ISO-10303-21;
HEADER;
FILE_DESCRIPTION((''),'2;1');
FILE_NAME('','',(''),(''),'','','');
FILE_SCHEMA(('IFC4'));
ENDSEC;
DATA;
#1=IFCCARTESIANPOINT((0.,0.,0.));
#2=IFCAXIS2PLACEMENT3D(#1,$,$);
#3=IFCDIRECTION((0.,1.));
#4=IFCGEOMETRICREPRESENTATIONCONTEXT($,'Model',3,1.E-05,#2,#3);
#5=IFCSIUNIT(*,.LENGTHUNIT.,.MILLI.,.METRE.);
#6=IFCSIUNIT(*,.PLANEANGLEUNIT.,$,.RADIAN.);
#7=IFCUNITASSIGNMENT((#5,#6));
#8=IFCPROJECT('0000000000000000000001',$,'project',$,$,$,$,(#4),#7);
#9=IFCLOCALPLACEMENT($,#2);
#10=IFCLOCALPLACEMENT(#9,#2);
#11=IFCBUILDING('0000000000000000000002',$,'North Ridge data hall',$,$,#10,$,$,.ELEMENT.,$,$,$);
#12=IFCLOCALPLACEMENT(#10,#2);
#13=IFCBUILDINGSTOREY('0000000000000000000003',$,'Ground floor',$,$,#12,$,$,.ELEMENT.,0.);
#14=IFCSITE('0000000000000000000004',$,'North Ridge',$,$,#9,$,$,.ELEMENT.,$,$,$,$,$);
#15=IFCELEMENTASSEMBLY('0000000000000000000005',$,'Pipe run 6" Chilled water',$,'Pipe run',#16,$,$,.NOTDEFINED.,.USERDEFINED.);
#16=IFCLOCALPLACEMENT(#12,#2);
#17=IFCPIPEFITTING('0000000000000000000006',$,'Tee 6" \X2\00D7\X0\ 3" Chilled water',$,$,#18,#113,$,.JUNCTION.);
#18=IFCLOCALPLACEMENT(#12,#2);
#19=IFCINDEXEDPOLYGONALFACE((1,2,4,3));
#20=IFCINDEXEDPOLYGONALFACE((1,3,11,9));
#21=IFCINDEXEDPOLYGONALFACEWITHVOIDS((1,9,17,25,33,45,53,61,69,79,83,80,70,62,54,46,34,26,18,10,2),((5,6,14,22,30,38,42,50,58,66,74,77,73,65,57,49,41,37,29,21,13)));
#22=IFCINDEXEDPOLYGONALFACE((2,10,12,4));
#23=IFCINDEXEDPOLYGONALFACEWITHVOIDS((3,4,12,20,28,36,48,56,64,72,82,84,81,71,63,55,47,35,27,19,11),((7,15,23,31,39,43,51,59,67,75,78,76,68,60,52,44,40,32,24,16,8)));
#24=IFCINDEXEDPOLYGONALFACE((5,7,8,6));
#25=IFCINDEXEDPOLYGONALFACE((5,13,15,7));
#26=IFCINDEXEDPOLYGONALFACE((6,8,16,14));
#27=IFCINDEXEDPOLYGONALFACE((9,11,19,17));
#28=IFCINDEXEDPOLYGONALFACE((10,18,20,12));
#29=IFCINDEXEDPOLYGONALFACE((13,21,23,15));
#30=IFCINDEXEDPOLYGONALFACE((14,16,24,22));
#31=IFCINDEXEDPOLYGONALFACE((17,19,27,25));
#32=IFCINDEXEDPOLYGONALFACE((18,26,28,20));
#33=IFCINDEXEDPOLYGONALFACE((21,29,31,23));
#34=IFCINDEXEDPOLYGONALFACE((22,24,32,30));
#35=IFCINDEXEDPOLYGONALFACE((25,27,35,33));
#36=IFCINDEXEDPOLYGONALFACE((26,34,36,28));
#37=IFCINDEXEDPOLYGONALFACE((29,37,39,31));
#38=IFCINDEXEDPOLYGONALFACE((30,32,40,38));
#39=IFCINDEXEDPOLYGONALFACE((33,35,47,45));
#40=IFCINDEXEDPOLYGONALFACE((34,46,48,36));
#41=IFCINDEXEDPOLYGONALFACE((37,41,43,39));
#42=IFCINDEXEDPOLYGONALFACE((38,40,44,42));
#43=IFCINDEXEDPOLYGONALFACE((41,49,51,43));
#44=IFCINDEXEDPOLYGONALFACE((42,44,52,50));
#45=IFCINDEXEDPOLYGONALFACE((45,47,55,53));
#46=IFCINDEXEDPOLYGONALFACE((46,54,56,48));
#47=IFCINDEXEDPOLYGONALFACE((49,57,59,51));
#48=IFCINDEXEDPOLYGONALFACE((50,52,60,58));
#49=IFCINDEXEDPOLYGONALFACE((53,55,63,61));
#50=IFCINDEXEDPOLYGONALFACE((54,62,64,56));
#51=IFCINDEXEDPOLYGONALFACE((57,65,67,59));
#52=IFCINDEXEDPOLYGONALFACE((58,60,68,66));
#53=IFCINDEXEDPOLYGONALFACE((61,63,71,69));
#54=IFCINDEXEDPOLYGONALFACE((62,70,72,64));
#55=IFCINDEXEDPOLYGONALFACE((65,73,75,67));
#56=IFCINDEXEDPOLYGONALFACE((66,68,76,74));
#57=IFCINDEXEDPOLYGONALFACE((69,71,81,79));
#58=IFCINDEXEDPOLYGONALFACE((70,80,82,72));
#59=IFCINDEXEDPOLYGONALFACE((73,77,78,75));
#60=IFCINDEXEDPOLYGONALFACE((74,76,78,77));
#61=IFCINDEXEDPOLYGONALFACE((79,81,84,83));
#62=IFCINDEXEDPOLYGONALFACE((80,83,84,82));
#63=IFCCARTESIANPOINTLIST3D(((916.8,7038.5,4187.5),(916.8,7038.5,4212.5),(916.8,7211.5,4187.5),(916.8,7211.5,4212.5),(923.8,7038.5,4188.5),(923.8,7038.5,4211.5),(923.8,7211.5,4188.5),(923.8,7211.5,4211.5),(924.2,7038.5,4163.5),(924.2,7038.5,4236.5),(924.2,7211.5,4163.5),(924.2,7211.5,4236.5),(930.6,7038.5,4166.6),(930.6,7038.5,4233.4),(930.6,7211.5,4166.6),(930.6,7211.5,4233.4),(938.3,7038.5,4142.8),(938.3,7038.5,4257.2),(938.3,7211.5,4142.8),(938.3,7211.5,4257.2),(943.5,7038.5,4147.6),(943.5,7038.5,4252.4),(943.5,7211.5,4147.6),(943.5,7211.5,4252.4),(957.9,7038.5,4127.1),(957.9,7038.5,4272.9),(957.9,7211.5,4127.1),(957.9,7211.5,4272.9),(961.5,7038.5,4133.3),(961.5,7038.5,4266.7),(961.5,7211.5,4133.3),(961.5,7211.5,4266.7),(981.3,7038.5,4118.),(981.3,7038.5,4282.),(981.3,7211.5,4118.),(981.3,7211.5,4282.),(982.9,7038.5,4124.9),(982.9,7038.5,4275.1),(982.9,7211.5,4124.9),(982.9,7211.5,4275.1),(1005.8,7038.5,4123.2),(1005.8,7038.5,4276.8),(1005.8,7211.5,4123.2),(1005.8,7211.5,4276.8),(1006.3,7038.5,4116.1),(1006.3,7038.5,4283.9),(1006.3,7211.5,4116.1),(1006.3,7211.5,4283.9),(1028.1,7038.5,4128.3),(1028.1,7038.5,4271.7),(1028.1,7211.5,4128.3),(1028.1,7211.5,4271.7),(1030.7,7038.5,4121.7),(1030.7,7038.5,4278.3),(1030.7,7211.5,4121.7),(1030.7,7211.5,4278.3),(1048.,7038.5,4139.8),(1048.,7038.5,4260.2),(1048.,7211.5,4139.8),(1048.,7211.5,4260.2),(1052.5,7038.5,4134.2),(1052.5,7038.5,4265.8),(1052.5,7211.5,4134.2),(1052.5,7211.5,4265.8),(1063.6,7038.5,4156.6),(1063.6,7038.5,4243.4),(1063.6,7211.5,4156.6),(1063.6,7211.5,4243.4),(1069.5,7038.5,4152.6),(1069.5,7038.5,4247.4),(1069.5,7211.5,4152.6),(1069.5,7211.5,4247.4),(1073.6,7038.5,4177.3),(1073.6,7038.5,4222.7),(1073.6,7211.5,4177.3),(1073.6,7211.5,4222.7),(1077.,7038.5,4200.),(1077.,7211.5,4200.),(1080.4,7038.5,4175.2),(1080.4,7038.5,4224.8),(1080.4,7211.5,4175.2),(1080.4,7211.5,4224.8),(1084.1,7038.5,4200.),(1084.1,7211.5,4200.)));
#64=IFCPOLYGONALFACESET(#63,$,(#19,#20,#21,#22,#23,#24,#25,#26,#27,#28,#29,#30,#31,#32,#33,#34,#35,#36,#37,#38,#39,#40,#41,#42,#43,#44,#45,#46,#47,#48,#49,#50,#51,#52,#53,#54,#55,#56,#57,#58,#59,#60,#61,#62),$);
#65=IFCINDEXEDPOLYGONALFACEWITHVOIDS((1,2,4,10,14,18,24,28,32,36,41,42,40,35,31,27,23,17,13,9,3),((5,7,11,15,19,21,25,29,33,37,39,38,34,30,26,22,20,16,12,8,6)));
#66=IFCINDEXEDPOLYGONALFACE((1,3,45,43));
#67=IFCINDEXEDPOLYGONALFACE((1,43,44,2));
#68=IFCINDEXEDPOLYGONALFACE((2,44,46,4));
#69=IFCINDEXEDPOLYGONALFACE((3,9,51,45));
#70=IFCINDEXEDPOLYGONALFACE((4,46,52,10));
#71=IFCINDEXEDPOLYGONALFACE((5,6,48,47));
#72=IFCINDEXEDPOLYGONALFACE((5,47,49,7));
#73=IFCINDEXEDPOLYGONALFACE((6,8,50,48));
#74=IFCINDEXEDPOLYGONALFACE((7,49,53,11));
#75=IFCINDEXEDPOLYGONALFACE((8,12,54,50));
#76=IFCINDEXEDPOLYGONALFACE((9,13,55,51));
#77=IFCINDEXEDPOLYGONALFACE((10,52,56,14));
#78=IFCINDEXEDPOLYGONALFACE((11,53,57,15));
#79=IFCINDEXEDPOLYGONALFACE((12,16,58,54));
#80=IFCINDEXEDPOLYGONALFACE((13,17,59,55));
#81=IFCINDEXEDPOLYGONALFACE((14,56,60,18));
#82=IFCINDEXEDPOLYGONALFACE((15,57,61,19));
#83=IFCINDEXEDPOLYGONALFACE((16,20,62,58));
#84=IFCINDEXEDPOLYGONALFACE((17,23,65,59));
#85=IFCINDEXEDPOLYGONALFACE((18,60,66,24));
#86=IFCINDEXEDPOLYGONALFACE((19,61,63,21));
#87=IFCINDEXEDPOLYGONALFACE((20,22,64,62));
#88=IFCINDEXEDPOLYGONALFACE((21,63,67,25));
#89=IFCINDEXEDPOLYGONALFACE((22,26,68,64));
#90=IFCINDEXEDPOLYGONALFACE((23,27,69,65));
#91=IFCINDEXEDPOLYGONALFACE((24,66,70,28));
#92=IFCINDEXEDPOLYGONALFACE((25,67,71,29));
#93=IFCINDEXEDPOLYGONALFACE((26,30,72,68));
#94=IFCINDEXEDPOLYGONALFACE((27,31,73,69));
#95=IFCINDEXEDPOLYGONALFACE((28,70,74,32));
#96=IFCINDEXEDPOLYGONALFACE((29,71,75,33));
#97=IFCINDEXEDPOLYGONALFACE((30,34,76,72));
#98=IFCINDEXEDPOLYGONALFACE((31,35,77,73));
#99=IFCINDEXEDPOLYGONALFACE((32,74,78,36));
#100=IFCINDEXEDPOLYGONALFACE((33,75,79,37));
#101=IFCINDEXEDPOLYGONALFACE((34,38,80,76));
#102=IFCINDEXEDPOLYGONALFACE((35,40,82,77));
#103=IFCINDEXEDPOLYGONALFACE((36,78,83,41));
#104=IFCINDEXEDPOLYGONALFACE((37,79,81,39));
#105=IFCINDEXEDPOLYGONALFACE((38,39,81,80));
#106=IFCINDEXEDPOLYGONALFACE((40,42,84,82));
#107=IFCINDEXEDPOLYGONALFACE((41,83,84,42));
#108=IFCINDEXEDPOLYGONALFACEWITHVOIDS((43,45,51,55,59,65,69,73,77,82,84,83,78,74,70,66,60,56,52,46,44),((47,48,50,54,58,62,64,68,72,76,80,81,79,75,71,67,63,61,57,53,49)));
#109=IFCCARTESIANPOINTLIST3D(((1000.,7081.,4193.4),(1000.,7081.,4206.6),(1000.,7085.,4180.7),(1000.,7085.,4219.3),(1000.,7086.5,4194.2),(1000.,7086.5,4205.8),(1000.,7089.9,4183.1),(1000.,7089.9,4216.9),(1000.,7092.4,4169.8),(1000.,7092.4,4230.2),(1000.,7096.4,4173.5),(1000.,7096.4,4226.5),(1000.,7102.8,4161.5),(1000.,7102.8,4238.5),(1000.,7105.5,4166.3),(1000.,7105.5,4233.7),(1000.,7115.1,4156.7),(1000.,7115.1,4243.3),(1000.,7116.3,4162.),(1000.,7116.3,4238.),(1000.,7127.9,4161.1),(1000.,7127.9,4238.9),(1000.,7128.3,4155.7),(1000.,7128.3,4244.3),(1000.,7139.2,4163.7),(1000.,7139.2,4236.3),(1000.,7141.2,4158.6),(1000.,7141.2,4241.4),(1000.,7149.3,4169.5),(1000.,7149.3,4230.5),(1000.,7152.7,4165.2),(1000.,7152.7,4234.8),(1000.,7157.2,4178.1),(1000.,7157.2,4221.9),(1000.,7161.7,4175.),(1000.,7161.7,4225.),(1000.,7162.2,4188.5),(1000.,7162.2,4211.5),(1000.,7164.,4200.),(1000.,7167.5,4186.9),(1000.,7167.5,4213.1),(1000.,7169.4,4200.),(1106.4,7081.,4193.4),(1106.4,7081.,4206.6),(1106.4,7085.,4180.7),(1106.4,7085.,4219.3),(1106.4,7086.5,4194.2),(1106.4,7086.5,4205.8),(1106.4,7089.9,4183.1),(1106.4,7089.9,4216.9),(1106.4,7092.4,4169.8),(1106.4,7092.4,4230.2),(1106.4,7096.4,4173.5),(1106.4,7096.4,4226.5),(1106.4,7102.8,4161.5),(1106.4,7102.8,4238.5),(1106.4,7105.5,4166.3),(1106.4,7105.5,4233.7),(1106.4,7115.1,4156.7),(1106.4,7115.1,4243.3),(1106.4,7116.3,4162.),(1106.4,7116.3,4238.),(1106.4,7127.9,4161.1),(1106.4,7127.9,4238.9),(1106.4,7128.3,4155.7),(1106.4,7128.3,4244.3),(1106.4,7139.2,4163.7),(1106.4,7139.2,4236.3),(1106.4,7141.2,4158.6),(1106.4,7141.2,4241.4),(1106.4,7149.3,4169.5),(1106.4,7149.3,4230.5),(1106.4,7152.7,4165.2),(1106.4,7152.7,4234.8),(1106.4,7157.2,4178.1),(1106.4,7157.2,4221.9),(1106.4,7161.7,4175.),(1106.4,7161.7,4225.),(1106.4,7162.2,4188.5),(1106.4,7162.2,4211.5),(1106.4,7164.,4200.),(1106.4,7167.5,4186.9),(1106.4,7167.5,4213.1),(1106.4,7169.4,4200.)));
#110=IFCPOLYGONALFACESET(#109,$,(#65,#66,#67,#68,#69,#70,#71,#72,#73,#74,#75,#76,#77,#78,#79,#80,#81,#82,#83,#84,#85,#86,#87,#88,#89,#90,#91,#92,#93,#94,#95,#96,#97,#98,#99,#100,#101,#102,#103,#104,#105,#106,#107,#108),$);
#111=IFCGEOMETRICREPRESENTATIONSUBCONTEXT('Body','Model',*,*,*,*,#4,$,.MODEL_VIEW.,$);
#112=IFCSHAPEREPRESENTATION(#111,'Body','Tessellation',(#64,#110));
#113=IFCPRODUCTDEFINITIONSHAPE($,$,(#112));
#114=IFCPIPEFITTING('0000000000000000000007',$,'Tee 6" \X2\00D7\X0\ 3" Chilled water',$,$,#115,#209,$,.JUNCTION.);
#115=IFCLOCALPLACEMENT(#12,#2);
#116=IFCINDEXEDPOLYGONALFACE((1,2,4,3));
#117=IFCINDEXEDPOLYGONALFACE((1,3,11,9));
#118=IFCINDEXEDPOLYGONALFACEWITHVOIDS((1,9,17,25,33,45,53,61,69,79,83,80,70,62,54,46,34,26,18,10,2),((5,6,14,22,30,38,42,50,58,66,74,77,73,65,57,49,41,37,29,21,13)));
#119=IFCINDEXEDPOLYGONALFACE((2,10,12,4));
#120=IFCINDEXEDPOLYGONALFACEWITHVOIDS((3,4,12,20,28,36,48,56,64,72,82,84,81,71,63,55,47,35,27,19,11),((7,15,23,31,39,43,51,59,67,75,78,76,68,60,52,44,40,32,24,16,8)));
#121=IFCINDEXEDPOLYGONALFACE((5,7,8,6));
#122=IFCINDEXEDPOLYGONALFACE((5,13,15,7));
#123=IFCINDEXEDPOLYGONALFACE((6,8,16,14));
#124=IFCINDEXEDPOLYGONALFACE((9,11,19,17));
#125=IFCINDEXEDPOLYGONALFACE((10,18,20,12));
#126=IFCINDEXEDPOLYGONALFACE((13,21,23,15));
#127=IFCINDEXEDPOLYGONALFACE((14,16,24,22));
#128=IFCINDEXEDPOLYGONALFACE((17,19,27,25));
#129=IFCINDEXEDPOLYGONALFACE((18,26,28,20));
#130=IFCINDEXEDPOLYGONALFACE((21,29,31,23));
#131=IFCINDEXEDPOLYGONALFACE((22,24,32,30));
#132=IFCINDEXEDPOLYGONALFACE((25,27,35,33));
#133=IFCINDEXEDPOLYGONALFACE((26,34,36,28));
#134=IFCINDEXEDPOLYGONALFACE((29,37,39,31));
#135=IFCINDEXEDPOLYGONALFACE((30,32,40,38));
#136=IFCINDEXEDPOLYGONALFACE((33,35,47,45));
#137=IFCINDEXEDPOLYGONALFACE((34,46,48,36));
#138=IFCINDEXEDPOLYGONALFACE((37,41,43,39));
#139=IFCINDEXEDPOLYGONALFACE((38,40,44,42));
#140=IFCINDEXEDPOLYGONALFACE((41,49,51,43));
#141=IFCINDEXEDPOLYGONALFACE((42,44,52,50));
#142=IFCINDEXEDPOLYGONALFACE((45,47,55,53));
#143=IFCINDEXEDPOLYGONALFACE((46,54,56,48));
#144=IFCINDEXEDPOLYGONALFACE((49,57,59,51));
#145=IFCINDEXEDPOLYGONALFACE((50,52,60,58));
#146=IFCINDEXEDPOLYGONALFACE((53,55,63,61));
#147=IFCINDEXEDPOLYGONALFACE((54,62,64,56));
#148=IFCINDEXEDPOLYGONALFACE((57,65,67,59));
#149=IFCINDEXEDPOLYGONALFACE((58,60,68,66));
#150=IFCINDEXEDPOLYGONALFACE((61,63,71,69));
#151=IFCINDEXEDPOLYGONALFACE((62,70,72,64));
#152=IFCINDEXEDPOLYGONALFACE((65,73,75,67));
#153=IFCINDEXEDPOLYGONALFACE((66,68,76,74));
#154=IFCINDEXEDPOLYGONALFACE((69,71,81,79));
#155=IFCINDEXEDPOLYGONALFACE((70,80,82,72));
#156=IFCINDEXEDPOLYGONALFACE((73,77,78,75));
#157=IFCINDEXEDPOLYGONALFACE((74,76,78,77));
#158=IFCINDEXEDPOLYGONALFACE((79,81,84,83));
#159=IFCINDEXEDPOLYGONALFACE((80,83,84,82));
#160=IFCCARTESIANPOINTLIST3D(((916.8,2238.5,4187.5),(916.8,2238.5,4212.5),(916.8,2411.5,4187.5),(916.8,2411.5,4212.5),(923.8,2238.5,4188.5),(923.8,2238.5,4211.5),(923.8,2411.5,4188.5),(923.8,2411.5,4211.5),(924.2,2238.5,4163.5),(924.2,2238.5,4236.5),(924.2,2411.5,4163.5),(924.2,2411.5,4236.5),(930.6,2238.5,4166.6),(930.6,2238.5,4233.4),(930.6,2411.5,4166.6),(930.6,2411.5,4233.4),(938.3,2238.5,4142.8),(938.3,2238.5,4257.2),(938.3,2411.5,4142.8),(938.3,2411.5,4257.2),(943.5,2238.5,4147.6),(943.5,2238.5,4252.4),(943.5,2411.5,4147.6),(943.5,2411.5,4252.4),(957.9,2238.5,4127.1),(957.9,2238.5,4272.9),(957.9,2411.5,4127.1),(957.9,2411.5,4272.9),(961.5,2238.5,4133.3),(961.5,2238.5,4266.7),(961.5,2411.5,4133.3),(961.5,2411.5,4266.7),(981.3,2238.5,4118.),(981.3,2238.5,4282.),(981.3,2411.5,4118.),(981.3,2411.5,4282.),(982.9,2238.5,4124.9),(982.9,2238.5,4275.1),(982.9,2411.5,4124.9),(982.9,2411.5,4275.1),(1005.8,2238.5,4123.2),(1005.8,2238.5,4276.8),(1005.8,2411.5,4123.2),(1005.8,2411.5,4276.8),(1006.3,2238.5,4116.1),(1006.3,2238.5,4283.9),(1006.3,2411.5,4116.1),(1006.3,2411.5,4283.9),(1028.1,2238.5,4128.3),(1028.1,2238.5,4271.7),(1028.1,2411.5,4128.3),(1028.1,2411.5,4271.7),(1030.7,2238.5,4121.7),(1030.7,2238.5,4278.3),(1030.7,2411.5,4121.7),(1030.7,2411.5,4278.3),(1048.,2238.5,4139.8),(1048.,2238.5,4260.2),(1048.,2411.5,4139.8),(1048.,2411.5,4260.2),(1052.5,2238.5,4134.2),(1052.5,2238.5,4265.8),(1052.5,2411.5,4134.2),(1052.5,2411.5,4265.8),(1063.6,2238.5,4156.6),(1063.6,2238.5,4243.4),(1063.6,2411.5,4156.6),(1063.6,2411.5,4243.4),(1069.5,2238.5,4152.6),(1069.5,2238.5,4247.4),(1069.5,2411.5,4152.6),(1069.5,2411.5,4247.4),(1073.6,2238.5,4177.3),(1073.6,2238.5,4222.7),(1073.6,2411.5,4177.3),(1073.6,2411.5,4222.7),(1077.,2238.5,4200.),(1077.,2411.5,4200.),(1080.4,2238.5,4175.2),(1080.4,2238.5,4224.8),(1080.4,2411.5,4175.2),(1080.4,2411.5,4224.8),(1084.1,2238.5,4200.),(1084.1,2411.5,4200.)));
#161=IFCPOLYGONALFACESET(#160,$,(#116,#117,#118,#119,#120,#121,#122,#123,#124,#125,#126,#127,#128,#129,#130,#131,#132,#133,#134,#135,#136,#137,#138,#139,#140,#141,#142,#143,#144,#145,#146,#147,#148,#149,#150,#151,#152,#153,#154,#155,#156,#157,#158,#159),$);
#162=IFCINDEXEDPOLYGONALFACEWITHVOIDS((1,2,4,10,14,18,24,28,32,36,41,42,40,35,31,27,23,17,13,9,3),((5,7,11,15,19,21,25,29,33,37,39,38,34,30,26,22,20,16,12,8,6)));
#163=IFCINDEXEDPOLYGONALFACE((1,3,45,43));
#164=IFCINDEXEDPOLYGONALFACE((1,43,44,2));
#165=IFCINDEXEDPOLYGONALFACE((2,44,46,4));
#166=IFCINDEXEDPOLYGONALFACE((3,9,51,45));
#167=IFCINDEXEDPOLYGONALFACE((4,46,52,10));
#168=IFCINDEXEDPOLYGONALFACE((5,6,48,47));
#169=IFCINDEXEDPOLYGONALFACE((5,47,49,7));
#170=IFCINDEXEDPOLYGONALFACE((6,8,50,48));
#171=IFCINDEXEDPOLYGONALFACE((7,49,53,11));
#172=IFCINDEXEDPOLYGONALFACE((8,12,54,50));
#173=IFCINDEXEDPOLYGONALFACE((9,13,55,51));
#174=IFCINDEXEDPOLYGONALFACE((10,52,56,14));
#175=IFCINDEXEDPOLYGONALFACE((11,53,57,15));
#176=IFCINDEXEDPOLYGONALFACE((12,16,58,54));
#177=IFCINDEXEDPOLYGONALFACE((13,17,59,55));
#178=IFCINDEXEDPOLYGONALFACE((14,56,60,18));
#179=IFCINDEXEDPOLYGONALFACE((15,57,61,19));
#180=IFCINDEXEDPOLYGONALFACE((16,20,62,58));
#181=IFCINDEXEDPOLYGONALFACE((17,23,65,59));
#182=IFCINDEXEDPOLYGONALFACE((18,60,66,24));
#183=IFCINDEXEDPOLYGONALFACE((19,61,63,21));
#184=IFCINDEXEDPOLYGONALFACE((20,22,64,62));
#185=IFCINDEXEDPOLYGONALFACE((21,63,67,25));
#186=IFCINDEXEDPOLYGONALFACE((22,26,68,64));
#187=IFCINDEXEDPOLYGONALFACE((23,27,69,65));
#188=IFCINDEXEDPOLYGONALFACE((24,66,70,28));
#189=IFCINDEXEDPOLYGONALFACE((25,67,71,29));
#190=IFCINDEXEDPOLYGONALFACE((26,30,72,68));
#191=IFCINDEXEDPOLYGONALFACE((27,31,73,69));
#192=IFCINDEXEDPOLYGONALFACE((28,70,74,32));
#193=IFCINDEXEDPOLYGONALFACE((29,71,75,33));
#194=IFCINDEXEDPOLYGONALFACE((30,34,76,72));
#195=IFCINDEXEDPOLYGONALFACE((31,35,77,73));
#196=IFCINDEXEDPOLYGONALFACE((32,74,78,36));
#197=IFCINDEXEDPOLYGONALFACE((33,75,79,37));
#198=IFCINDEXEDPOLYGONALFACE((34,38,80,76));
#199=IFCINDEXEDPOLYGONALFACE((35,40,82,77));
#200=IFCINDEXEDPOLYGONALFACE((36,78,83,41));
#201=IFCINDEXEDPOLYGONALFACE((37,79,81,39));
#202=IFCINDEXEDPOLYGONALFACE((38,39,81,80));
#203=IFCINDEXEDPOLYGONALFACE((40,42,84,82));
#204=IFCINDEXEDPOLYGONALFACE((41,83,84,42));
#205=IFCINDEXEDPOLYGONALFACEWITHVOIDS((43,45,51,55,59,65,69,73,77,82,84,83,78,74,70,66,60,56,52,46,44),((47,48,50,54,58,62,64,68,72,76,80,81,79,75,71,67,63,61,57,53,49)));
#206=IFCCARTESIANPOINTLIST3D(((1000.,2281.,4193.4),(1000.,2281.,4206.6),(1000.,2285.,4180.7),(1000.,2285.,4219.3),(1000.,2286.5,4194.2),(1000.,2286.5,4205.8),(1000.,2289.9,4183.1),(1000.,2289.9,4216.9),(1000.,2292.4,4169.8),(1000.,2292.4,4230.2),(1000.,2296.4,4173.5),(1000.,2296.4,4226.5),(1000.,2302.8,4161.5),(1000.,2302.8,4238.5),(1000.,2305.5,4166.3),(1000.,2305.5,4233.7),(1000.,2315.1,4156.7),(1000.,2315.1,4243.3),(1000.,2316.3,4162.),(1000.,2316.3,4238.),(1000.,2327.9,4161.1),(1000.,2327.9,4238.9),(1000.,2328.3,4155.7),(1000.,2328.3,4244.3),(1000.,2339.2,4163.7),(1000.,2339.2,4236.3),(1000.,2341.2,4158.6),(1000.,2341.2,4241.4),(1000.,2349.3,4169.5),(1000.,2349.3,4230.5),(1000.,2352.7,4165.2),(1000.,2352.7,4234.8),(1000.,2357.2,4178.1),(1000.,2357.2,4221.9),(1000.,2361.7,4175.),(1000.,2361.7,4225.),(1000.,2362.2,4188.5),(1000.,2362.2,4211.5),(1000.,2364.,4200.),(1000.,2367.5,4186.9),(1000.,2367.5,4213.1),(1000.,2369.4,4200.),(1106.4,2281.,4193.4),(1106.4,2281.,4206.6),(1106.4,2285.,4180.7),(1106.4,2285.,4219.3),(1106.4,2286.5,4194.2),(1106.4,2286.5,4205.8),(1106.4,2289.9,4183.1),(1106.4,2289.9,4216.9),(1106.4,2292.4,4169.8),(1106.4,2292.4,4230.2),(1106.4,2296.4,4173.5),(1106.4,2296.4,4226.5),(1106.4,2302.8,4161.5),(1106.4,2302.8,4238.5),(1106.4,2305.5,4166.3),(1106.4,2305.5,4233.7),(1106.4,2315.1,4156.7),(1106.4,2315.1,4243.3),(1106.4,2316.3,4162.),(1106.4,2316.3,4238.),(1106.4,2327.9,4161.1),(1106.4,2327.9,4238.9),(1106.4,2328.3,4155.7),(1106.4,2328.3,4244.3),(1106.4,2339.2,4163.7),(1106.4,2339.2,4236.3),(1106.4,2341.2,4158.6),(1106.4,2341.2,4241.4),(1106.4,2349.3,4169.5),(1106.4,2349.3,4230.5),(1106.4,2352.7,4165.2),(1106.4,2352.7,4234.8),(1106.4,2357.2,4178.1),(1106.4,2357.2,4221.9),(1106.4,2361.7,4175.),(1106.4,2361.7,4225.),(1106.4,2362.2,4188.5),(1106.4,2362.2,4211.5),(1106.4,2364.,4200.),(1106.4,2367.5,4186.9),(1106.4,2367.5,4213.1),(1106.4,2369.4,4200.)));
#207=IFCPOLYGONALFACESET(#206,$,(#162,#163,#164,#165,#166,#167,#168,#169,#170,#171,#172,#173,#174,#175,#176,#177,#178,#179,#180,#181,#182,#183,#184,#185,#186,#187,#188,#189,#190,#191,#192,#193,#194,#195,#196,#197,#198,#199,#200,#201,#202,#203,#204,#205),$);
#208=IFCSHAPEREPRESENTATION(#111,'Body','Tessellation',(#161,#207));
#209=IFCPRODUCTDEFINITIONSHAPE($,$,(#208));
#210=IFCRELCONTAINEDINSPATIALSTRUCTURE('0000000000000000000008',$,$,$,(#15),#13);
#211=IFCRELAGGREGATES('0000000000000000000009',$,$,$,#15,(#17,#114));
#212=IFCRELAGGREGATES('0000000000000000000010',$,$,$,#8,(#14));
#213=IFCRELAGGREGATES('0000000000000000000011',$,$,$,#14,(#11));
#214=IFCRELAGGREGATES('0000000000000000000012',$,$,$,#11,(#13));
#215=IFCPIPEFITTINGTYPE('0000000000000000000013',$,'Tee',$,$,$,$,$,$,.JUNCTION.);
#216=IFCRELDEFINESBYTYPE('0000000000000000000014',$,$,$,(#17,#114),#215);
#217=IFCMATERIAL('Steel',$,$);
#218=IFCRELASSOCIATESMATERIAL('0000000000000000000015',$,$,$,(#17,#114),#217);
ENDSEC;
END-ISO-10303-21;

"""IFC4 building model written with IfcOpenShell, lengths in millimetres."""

from ifc_helpers import new_model, si_unit, direction, frame, origin, origin_with_axes, origin_2d, place, context, subcontext, project, spatial, hollow_circle, extrude, material, type_object, element, aggregate, save


model = new_model("IFC4")

# Units and contexts
model_context = context("Model", 3, precision=1e-05, world=origin(), true_north=direction((0.0, 1.0)))
body_context = subcontext(model_context, "Body", "Model", "MODEL_VIEW")
ifc_project = project(units=[si_unit("LENGTHUNIT", "METRE", prefix="MILLI"), si_unit("PLANEANGLEUNIT", "RADIAN")], contexts=[model_context])

# Site, building, storey
site_placement = place(None, origin())
site = spatial("IfcSite", under=ifc_project, at=site_placement, Name="North Ridge", CompositionType="ELEMENT")
building_placement = place(site_placement, origin())
building = spatial("IfcBuilding", under=site, at=building_placement, Name="North Ridge data hall", CompositionType="ELEMENT")
storey_placement = place(building_placement, origin())
storey = spatial("IfcBuildingStorey", under=building, at=storey_placement, Name="Ground floor", CompositionType="ELEMENT", Elevation=0.0)

# Element assembly
assembly_1_placement = place(storey_placement, origin_with_axes())
assembly_1 = element("IfcElementAssembly", 1, at=assembly_1_placement, inside=storey, Name="Pipe run 6\" Chilled water", ObjectType="Pipe run", AssemblyPlace="NOTDEFINED", PredefinedType="USERDEFINED")
ifc_material_1 = material(Name="Steel")

# Pipe fittings
pipe_fitting_type_1 = type_object("IfcPipeFittingType", Name="Tee", PredefinedType="JUNCTION")
pipe_fitting_1_placement = place(storey_placement, origin_with_axes())
pipe_fitting_1 = element("IfcPipeFitting", 2, at=pipe_fitting_1_placement, type_object=pipe_fitting_type_1, material=ifc_material_1, Name="Tee 6\" × 3\" Chilled water", PredefinedType="JUNCTION", context=body_context, shape_type="SweptSolid", body=[
    extrude(hollow_circle(Radius=84.1, WallThickness=7.1, at=origin_2d()), frame((1000.0, 7211.5, 4200.0), z_axis=(0.0, -1.0, 0.0), x_axis=(1.0, 0.0, 0.0)), (0.0, 0.0, 1.0), 173.0),
    extrude(hollow_circle(Radius=44.5, WallThickness=5.5, at=origin_2d()), frame((1000.0, 7125.0, 4200.0), z_axis=(1.0, 0.0, 0.0), x_axis=(0.0, 1.0, 0.0)), (0.0, 0.0, 1.0), 106.4),
])
pipe_fitting_2_placement = place(storey_placement, origin_with_axes())
pipe_fitting_2 = element("IfcPipeFitting", 3, at=pipe_fitting_2_placement, type_object=pipe_fitting_type_1, material=ifc_material_1, Name="Tee 6\" × 3\" Chilled water", PredefinedType="JUNCTION", context=body_context, shape_type="SweptSolid", body=[
    extrude(hollow_circle(Radius=84.1, WallThickness=7.1, at=origin_2d()), frame((1000.0, 2411.5, 4200.0), z_axis=(0.0, -1.0, 0.0), x_axis=(1.0, 0.0, 0.0)), (0.0, 0.0, 1.0), 173.0),
    extrude(hollow_circle(Radius=44.5, WallThickness=5.5, at=origin_2d()), frame((1000.0, 2325.0, 4200.0), z_axis=(1.0, 0.0, 0.0), x_axis=(0.0, 1.0, 0.0)), (0.0, 0.0, 1.0), 106.4),
])
aggregate(assembly_1, [pipe_fitting_1, pipe_fitting_2])

save(model, "model.ifc")
